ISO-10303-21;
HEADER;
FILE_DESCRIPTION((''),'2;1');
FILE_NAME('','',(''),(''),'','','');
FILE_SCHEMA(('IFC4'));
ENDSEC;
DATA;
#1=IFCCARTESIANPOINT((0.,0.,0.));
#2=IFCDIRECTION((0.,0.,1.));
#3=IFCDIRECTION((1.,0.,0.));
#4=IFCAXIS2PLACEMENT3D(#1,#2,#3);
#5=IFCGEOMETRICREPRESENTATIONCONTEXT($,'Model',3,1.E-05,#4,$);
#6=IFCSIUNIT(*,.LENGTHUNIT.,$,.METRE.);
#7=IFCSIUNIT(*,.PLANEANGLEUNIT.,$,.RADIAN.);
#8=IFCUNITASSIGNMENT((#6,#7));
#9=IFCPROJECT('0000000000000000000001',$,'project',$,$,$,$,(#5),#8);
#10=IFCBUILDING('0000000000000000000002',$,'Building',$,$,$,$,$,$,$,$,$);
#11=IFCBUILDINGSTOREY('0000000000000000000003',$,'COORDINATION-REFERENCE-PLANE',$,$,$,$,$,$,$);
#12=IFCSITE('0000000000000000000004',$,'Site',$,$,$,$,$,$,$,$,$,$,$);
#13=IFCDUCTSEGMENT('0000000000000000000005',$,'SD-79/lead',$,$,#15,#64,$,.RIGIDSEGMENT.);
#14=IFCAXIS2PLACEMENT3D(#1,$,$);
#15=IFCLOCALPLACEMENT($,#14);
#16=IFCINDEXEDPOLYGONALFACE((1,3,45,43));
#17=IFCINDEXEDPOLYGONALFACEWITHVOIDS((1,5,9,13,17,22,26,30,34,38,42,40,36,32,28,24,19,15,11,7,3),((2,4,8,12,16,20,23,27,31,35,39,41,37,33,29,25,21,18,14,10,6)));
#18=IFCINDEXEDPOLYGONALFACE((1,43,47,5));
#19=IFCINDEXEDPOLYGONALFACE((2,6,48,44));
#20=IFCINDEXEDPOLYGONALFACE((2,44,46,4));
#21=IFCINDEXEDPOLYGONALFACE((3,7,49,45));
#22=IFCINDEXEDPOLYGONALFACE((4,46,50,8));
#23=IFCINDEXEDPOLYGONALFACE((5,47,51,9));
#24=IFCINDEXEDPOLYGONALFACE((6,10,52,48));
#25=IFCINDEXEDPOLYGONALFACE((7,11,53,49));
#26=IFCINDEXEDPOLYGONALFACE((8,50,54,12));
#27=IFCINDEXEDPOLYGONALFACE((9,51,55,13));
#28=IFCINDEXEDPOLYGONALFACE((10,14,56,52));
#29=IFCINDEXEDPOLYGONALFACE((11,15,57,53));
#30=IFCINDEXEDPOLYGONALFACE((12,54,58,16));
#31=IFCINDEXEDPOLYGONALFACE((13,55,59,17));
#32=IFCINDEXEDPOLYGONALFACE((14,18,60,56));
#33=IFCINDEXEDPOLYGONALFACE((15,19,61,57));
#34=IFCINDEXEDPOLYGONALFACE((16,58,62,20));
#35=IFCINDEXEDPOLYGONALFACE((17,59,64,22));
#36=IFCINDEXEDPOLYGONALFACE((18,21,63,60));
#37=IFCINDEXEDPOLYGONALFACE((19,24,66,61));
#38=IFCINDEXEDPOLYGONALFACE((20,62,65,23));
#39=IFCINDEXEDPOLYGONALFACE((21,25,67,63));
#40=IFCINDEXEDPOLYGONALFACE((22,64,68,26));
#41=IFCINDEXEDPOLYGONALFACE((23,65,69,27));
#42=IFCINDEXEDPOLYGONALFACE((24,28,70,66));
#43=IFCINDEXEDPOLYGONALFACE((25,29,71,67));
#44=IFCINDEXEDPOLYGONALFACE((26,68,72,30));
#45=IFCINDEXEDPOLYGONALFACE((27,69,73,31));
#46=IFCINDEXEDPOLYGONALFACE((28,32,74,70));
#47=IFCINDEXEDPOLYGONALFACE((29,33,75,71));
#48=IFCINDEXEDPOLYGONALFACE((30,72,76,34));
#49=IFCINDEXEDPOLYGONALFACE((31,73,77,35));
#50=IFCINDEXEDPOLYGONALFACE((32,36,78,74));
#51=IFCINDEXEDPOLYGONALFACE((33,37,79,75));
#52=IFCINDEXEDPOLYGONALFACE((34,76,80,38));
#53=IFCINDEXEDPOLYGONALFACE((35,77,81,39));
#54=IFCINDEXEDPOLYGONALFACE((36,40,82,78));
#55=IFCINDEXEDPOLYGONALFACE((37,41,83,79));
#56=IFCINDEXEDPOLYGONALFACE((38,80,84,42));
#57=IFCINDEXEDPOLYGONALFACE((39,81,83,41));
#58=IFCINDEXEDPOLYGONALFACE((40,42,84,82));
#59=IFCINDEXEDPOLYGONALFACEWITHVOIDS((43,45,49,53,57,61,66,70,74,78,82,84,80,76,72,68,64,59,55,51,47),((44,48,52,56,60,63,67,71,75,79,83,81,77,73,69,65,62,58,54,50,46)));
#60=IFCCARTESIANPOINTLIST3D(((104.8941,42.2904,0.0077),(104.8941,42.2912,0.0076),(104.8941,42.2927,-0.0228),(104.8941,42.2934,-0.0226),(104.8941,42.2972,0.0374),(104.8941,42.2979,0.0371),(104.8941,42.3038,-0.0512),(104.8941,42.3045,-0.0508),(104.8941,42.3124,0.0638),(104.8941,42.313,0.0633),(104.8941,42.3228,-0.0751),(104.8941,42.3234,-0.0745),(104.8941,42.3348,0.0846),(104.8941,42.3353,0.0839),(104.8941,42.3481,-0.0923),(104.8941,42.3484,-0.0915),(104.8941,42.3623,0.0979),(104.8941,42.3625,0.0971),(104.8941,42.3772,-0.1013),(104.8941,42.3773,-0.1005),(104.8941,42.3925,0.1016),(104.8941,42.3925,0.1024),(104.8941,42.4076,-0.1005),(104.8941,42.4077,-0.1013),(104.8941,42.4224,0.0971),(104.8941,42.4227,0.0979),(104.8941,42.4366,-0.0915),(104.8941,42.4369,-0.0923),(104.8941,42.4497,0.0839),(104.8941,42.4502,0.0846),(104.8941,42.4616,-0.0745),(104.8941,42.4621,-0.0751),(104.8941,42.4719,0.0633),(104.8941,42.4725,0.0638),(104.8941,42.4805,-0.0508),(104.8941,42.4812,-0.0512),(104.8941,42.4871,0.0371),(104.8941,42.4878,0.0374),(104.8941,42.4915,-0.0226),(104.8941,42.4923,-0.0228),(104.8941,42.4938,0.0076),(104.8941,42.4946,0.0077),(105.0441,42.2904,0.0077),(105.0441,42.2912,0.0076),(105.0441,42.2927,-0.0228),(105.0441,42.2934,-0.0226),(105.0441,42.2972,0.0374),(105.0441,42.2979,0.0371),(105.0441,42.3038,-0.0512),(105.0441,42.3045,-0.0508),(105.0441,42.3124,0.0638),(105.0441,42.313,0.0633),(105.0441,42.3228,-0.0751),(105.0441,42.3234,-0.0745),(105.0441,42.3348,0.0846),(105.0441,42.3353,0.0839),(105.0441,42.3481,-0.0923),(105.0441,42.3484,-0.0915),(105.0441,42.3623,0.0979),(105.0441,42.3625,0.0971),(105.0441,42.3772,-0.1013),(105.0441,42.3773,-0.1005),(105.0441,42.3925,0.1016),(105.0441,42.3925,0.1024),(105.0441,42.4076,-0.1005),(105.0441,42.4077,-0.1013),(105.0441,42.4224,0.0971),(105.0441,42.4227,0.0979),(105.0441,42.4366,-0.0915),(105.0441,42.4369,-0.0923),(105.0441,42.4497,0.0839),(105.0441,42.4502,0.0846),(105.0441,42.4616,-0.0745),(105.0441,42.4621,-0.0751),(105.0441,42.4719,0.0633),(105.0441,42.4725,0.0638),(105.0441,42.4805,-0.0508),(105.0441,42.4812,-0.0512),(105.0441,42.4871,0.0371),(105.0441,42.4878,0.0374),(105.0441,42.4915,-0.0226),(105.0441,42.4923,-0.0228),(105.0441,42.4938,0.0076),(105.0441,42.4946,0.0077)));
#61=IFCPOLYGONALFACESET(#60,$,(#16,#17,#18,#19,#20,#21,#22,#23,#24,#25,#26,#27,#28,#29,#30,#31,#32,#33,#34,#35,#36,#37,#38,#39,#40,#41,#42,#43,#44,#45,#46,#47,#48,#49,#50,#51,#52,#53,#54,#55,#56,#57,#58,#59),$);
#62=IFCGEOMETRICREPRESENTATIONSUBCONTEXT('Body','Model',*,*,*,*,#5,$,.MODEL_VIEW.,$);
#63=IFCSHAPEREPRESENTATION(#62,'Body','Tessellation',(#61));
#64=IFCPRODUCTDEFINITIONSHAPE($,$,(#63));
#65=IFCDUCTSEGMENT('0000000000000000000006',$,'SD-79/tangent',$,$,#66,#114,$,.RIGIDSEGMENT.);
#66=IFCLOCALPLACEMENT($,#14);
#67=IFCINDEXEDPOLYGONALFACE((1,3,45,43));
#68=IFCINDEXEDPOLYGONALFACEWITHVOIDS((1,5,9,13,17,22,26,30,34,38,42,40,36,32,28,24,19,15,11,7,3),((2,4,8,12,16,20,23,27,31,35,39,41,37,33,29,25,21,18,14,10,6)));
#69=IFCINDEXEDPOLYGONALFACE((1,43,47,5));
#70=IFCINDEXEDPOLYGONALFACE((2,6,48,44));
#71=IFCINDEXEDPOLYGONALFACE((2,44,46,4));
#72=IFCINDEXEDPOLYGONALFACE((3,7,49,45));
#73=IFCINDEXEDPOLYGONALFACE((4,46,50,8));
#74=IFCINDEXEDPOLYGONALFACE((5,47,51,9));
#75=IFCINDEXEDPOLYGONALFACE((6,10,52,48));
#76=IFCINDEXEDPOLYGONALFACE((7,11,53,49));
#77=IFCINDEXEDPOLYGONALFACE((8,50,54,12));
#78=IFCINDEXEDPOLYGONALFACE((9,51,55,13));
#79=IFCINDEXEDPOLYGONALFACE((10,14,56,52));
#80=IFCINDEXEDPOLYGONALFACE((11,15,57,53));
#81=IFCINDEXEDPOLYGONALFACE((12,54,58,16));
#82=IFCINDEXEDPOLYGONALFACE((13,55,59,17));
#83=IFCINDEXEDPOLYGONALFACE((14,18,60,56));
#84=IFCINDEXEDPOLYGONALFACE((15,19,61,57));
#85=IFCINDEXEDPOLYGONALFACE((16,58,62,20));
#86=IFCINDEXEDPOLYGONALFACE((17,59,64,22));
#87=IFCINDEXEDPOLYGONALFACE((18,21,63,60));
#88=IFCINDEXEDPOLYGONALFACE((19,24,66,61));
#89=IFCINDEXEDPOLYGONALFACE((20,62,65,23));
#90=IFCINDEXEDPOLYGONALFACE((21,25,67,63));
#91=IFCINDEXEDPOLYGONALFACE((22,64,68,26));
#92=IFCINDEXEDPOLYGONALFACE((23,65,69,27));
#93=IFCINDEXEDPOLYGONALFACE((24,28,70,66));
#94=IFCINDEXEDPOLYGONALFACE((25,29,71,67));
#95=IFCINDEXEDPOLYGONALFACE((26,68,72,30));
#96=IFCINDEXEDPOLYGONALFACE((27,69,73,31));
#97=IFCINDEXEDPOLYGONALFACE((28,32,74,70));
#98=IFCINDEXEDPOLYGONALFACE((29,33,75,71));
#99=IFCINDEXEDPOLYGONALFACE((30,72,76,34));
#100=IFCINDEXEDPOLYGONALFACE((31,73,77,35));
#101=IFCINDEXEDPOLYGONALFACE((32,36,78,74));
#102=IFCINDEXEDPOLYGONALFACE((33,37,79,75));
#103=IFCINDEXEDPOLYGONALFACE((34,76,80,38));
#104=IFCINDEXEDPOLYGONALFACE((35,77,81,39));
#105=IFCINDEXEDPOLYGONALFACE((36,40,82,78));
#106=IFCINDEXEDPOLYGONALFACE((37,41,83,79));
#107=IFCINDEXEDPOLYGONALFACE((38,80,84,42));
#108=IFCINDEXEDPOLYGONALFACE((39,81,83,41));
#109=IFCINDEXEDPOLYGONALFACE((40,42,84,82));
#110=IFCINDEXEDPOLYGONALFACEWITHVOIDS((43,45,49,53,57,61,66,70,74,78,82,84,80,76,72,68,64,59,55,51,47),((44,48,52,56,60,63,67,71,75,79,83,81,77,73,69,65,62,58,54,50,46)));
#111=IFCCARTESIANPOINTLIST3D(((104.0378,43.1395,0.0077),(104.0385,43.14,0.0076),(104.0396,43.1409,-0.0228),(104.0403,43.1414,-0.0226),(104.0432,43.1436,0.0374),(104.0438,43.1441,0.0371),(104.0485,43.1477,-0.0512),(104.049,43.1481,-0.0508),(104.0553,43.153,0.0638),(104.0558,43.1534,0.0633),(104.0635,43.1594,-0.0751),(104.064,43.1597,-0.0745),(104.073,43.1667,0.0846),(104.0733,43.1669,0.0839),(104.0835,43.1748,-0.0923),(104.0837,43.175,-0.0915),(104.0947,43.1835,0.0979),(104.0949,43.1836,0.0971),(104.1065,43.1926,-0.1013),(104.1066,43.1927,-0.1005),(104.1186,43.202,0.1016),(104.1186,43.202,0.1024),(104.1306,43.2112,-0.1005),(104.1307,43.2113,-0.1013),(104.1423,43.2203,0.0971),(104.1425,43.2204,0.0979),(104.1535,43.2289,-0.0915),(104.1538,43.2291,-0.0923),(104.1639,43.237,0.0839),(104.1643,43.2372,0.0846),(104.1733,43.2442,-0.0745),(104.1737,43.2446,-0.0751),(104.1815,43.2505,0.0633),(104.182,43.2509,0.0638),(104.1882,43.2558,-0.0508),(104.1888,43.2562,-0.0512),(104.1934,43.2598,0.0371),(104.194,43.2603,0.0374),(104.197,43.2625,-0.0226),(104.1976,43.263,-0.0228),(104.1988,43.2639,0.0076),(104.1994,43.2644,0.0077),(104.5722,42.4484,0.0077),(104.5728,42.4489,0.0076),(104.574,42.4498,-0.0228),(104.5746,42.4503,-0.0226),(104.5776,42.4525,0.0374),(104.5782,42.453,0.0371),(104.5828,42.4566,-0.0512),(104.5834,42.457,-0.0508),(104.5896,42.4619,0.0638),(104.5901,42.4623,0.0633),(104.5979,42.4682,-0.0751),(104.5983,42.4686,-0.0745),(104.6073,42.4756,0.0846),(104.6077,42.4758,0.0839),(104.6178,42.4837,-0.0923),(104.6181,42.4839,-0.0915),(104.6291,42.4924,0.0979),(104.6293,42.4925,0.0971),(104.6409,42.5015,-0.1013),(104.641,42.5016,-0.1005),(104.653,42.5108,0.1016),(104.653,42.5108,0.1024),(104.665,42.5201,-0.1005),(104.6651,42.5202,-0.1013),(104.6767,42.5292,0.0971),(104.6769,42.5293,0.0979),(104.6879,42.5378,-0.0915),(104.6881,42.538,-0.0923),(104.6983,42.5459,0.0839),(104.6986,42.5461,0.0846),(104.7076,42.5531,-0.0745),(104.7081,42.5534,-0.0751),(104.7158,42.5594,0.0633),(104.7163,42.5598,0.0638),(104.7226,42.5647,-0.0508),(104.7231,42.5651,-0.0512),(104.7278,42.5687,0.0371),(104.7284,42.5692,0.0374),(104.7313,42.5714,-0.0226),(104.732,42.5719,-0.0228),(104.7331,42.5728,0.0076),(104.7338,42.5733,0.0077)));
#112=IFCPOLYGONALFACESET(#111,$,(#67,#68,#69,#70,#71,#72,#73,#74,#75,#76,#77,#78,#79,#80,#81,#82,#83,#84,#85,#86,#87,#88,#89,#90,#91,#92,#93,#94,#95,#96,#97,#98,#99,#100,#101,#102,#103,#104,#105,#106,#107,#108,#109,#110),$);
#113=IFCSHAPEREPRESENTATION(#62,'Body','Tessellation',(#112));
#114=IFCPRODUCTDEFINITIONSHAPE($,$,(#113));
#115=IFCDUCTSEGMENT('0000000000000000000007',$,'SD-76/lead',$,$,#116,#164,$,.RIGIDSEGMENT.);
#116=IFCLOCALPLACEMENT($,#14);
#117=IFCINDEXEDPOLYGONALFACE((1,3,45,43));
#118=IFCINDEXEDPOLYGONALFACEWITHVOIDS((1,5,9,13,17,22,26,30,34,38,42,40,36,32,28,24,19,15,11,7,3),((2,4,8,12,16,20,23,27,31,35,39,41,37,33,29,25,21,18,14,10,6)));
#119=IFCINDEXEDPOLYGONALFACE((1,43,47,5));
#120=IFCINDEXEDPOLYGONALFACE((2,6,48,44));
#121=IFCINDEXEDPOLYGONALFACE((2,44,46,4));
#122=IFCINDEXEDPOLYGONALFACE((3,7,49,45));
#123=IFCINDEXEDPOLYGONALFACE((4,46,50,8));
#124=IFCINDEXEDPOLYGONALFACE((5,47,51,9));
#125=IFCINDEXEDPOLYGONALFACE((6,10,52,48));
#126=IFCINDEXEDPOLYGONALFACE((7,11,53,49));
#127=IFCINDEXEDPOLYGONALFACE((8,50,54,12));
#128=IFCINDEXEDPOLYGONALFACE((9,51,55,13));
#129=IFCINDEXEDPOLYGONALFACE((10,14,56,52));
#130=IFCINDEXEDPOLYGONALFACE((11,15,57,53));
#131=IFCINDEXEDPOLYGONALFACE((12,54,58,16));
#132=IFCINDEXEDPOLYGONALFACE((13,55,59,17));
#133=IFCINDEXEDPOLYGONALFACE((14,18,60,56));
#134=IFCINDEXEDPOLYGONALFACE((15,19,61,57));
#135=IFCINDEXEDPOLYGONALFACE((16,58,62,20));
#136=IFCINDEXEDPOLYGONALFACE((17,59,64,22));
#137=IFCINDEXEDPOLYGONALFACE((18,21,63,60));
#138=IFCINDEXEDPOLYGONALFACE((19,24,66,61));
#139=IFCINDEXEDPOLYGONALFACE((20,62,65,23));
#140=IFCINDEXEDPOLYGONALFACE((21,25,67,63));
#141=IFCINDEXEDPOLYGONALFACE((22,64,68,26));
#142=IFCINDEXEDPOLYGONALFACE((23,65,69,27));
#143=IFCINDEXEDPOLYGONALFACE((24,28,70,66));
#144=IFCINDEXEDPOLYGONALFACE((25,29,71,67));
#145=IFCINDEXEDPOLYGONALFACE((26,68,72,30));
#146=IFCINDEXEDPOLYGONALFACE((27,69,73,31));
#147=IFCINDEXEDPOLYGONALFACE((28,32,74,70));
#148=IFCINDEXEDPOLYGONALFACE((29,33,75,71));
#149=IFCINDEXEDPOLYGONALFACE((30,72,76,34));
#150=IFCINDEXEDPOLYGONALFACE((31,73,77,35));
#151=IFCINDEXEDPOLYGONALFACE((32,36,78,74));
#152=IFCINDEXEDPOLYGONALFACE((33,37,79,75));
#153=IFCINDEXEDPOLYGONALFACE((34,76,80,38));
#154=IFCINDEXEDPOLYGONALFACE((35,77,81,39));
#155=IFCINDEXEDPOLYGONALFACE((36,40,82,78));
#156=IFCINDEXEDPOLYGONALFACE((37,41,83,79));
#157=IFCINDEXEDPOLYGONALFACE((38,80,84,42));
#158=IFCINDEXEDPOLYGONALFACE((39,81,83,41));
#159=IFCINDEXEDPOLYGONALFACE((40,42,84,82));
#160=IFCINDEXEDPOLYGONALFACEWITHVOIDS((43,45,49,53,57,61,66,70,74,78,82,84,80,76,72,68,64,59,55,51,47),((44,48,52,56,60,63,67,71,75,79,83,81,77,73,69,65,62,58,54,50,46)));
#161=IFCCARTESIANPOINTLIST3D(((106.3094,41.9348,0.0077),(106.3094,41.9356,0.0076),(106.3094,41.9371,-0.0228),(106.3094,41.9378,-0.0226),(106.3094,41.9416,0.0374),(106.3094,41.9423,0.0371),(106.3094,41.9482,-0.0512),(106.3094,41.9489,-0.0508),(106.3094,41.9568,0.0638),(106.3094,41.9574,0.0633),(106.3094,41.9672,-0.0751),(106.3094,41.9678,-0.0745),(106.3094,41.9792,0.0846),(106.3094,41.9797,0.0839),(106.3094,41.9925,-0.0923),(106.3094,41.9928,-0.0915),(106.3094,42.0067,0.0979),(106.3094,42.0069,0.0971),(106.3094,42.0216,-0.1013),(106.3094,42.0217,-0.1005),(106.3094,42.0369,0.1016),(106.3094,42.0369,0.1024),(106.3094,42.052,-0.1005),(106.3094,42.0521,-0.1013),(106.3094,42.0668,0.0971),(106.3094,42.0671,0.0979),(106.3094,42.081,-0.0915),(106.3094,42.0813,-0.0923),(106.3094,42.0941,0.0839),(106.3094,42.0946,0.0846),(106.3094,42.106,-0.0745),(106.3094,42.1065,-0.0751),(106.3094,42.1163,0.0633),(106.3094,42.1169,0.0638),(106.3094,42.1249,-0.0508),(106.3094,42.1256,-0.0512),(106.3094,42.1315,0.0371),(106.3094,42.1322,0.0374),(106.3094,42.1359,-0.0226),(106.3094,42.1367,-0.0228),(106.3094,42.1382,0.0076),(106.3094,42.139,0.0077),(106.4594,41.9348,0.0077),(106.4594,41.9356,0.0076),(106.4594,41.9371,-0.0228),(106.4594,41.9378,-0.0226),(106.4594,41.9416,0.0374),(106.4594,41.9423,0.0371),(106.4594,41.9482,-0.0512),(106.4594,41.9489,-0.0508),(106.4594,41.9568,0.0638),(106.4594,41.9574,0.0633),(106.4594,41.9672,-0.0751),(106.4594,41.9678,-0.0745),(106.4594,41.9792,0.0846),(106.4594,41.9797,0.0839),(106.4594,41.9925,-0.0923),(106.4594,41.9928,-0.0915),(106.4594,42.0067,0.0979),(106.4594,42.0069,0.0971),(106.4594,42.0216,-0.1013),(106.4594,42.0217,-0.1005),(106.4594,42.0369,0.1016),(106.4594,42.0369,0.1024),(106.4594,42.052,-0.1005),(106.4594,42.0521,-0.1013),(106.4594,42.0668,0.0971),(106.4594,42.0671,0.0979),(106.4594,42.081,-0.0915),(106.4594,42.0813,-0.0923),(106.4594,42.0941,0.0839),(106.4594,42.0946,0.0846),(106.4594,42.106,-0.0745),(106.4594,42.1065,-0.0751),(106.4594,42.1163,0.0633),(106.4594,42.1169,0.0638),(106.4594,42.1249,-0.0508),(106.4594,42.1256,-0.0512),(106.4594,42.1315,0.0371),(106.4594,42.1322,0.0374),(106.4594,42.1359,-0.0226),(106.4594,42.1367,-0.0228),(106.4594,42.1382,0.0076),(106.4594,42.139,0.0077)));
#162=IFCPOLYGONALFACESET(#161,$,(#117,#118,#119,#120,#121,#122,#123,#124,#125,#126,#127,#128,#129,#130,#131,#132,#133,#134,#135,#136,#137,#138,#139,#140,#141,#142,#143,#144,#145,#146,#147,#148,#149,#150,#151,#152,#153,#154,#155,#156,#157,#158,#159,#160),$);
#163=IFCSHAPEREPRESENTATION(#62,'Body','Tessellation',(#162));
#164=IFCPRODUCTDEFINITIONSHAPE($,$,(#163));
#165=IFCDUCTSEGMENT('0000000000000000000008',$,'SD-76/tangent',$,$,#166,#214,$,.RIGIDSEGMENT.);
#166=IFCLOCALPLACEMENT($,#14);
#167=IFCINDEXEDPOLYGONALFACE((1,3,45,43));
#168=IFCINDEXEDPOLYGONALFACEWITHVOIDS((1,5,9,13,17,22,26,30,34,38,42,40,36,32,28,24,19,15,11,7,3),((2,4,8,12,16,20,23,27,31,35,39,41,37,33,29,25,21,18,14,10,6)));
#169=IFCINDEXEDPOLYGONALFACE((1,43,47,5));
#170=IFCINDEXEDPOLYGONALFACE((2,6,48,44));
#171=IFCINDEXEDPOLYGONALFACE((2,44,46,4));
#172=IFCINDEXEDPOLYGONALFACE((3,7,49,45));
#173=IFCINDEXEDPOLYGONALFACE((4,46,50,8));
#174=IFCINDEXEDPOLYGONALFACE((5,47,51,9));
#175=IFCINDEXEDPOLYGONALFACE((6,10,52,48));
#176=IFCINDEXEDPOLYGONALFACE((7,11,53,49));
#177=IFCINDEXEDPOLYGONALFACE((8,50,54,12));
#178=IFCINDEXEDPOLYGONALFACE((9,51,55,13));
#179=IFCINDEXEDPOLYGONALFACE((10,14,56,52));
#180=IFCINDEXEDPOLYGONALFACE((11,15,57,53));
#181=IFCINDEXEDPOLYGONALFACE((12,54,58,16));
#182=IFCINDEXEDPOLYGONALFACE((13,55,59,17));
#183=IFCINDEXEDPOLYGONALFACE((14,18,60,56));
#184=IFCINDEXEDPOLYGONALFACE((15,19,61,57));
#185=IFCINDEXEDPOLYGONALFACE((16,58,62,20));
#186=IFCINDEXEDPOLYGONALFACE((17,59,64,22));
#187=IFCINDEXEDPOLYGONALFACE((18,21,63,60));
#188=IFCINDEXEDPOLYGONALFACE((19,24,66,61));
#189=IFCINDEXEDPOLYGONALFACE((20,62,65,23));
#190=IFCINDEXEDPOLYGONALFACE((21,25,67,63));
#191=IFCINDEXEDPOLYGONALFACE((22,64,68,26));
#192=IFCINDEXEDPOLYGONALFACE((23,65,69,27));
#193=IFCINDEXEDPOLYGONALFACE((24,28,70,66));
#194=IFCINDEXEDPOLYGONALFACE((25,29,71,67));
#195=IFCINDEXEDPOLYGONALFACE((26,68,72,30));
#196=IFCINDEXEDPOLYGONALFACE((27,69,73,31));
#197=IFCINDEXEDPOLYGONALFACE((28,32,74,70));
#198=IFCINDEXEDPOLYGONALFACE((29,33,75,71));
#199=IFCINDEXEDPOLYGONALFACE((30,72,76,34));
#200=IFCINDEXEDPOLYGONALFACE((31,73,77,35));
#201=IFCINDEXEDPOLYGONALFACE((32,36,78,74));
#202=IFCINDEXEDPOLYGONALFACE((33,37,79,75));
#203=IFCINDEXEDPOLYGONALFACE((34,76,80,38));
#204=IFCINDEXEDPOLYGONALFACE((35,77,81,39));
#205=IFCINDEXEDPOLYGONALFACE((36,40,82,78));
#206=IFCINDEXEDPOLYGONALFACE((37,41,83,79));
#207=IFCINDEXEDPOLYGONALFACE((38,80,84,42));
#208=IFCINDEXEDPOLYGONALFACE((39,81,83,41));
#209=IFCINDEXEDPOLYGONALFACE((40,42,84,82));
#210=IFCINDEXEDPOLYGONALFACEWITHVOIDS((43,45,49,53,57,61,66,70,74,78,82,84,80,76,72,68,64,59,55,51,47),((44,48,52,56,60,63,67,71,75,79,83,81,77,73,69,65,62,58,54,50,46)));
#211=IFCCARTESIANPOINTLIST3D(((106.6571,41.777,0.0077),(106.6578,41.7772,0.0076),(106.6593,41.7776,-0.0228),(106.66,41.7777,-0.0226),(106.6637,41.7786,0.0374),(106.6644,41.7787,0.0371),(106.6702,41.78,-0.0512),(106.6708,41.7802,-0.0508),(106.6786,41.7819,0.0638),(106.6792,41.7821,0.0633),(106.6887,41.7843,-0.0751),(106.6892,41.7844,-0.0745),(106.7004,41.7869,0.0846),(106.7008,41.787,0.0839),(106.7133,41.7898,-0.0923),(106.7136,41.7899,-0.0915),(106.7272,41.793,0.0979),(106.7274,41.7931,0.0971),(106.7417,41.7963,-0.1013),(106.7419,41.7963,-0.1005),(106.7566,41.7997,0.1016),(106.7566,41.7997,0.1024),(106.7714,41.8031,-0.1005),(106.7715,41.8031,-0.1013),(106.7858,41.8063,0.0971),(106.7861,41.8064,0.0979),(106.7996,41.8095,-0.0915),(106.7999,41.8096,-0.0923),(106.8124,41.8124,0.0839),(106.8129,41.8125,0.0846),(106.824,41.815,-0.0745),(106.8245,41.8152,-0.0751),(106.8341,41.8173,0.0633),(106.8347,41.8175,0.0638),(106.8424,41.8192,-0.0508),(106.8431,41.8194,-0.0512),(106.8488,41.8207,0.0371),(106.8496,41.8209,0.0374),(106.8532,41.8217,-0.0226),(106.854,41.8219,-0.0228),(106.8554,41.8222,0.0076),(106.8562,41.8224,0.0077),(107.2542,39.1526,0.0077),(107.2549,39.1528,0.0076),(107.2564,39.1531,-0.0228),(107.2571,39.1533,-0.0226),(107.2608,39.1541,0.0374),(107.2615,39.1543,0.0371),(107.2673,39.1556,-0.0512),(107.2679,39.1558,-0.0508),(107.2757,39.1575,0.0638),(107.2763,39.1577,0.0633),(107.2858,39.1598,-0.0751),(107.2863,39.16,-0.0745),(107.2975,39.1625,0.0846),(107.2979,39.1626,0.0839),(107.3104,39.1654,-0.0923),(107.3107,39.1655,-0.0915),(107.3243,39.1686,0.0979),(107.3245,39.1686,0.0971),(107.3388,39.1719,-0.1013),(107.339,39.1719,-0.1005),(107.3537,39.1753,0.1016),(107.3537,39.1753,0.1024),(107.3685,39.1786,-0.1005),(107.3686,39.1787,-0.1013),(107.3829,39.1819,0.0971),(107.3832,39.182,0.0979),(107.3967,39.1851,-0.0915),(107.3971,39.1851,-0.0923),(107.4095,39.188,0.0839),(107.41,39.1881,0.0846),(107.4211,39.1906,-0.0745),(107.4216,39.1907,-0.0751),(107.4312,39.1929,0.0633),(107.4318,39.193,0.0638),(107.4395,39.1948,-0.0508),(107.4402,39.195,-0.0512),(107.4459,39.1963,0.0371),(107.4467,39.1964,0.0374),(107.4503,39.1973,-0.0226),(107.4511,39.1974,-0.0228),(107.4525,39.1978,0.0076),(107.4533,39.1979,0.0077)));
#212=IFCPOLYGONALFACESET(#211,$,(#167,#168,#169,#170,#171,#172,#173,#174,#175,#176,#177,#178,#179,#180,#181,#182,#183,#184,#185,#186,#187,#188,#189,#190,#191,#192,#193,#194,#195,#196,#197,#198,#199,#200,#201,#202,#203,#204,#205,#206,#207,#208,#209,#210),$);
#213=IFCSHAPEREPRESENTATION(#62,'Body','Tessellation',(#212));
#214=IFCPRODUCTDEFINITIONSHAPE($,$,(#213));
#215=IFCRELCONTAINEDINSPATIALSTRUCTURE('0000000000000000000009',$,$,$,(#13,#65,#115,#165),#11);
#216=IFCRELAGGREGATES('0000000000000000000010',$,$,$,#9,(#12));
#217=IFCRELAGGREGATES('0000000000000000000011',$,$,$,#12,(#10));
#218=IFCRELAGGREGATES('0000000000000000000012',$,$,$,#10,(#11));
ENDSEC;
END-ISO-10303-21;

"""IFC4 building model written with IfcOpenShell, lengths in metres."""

from ifc_helpers import new_model, si_unit, frame, origin_with_axes, place, context, subcontext, project, spatial, hollow_circle, extrude, element, save


model = new_model("IFC4")

# Units and contexts
model_context = context("Model", 3, precision=1e-05, world=origin_with_axes())
body_context_1 = subcontext(model_context, "Body", "Model", "MODEL_VIEW")
ifc_project = project(units=[si_unit("LENGTHUNIT", "METRE"), si_unit("PLANEANGLEUNIT", "RADIAN")], contexts=[model_context])

# Site, building, storey
site = spatial("IfcSite", under=ifc_project, Name="Site")
building = spatial("IfcBuilding", under=site, Name="Building")
storey = spatial("IfcBuildingStorey", under=building, Name="COORDINATION-REFERENCE-PLANE")

# Duct segment
duct_segment_1_placement = place(None, frame((105.0441, 42.3925, 0.0), z_axis=(-1.0, 0.0, 0.0), x_axis=(0.0, 0.0, 1.0)))
element("IfcDuctSegment", 1, at=duct_segment_1_placement, inside=storey, Name="SD-79/lead", PredefinedType="RIGIDSEGMENT", context=body_context_1, shape_type="SweptSolid", body=[
    extrude(hollow_circle(Radius=0.1024, WallThickness=0.0008), origin_with_axes(), (0.0, 0.0, 1.0), 0.15),
])

# Duct segment
duct_segment_2_placement = place(None, frame((104.653, 42.5108, 0.0), z_axis=(-0.611676, 0.791108, 0.0), x_axis=(0.0, 0.0, 1.0)))
element("IfcDuctSegment", 2, at=duct_segment_2_placement, inside=storey, Name="SD-79/tangent", PredefinedType="RIGIDSEGMENT", context=body_context_1, shape_type="SweptSolid", body=[
    extrude(hollow_circle(Radius=0.1024, WallThickness=0.0008), origin_with_axes(), (0.0, 0.0, 1.0), 0.8736),
])

# Duct segment
duct_segment_3_placement = place(None, frame((106.3094, 42.0369, 0.0), z_axis=(1.0, 0.0, 0.0), x_axis=(0.0, 0.0, 1.0)))
element("IfcDuctSegment", 3, at=duct_segment_3_placement, inside=storey, Name="SD-76/lead", PredefinedType="RIGIDSEGMENT", context=body_context_1, shape_type="SweptSolid", body=[
    extrude(hollow_circle(Radius=0.1024, WallThickness=0.0008), origin_with_axes(), (0.0, 0.0, 1.0), 0.15),
])

# Duct segment
duct_segment_4_placement = place(None, frame((106.7566, 41.7997, 0.0), z_axis=(0.221849, -0.975081, 0.0), x_axis=(0.0, 0.0, 1.0)))
element("IfcDuctSegment", 4, at=duct_segment_4_placement, inside=storey, Name="SD-76/tangent", PredefinedType="RIGIDSEGMENT", context=body_context_1, shape_type="SweptSolid", body=[
    extrude(hollow_circle(Radius=0.1024, WallThickness=0.0008), origin_with_axes(), (0.0, 0.0, 1.0), 2.6915),
])

save(model, "model.ifc")
